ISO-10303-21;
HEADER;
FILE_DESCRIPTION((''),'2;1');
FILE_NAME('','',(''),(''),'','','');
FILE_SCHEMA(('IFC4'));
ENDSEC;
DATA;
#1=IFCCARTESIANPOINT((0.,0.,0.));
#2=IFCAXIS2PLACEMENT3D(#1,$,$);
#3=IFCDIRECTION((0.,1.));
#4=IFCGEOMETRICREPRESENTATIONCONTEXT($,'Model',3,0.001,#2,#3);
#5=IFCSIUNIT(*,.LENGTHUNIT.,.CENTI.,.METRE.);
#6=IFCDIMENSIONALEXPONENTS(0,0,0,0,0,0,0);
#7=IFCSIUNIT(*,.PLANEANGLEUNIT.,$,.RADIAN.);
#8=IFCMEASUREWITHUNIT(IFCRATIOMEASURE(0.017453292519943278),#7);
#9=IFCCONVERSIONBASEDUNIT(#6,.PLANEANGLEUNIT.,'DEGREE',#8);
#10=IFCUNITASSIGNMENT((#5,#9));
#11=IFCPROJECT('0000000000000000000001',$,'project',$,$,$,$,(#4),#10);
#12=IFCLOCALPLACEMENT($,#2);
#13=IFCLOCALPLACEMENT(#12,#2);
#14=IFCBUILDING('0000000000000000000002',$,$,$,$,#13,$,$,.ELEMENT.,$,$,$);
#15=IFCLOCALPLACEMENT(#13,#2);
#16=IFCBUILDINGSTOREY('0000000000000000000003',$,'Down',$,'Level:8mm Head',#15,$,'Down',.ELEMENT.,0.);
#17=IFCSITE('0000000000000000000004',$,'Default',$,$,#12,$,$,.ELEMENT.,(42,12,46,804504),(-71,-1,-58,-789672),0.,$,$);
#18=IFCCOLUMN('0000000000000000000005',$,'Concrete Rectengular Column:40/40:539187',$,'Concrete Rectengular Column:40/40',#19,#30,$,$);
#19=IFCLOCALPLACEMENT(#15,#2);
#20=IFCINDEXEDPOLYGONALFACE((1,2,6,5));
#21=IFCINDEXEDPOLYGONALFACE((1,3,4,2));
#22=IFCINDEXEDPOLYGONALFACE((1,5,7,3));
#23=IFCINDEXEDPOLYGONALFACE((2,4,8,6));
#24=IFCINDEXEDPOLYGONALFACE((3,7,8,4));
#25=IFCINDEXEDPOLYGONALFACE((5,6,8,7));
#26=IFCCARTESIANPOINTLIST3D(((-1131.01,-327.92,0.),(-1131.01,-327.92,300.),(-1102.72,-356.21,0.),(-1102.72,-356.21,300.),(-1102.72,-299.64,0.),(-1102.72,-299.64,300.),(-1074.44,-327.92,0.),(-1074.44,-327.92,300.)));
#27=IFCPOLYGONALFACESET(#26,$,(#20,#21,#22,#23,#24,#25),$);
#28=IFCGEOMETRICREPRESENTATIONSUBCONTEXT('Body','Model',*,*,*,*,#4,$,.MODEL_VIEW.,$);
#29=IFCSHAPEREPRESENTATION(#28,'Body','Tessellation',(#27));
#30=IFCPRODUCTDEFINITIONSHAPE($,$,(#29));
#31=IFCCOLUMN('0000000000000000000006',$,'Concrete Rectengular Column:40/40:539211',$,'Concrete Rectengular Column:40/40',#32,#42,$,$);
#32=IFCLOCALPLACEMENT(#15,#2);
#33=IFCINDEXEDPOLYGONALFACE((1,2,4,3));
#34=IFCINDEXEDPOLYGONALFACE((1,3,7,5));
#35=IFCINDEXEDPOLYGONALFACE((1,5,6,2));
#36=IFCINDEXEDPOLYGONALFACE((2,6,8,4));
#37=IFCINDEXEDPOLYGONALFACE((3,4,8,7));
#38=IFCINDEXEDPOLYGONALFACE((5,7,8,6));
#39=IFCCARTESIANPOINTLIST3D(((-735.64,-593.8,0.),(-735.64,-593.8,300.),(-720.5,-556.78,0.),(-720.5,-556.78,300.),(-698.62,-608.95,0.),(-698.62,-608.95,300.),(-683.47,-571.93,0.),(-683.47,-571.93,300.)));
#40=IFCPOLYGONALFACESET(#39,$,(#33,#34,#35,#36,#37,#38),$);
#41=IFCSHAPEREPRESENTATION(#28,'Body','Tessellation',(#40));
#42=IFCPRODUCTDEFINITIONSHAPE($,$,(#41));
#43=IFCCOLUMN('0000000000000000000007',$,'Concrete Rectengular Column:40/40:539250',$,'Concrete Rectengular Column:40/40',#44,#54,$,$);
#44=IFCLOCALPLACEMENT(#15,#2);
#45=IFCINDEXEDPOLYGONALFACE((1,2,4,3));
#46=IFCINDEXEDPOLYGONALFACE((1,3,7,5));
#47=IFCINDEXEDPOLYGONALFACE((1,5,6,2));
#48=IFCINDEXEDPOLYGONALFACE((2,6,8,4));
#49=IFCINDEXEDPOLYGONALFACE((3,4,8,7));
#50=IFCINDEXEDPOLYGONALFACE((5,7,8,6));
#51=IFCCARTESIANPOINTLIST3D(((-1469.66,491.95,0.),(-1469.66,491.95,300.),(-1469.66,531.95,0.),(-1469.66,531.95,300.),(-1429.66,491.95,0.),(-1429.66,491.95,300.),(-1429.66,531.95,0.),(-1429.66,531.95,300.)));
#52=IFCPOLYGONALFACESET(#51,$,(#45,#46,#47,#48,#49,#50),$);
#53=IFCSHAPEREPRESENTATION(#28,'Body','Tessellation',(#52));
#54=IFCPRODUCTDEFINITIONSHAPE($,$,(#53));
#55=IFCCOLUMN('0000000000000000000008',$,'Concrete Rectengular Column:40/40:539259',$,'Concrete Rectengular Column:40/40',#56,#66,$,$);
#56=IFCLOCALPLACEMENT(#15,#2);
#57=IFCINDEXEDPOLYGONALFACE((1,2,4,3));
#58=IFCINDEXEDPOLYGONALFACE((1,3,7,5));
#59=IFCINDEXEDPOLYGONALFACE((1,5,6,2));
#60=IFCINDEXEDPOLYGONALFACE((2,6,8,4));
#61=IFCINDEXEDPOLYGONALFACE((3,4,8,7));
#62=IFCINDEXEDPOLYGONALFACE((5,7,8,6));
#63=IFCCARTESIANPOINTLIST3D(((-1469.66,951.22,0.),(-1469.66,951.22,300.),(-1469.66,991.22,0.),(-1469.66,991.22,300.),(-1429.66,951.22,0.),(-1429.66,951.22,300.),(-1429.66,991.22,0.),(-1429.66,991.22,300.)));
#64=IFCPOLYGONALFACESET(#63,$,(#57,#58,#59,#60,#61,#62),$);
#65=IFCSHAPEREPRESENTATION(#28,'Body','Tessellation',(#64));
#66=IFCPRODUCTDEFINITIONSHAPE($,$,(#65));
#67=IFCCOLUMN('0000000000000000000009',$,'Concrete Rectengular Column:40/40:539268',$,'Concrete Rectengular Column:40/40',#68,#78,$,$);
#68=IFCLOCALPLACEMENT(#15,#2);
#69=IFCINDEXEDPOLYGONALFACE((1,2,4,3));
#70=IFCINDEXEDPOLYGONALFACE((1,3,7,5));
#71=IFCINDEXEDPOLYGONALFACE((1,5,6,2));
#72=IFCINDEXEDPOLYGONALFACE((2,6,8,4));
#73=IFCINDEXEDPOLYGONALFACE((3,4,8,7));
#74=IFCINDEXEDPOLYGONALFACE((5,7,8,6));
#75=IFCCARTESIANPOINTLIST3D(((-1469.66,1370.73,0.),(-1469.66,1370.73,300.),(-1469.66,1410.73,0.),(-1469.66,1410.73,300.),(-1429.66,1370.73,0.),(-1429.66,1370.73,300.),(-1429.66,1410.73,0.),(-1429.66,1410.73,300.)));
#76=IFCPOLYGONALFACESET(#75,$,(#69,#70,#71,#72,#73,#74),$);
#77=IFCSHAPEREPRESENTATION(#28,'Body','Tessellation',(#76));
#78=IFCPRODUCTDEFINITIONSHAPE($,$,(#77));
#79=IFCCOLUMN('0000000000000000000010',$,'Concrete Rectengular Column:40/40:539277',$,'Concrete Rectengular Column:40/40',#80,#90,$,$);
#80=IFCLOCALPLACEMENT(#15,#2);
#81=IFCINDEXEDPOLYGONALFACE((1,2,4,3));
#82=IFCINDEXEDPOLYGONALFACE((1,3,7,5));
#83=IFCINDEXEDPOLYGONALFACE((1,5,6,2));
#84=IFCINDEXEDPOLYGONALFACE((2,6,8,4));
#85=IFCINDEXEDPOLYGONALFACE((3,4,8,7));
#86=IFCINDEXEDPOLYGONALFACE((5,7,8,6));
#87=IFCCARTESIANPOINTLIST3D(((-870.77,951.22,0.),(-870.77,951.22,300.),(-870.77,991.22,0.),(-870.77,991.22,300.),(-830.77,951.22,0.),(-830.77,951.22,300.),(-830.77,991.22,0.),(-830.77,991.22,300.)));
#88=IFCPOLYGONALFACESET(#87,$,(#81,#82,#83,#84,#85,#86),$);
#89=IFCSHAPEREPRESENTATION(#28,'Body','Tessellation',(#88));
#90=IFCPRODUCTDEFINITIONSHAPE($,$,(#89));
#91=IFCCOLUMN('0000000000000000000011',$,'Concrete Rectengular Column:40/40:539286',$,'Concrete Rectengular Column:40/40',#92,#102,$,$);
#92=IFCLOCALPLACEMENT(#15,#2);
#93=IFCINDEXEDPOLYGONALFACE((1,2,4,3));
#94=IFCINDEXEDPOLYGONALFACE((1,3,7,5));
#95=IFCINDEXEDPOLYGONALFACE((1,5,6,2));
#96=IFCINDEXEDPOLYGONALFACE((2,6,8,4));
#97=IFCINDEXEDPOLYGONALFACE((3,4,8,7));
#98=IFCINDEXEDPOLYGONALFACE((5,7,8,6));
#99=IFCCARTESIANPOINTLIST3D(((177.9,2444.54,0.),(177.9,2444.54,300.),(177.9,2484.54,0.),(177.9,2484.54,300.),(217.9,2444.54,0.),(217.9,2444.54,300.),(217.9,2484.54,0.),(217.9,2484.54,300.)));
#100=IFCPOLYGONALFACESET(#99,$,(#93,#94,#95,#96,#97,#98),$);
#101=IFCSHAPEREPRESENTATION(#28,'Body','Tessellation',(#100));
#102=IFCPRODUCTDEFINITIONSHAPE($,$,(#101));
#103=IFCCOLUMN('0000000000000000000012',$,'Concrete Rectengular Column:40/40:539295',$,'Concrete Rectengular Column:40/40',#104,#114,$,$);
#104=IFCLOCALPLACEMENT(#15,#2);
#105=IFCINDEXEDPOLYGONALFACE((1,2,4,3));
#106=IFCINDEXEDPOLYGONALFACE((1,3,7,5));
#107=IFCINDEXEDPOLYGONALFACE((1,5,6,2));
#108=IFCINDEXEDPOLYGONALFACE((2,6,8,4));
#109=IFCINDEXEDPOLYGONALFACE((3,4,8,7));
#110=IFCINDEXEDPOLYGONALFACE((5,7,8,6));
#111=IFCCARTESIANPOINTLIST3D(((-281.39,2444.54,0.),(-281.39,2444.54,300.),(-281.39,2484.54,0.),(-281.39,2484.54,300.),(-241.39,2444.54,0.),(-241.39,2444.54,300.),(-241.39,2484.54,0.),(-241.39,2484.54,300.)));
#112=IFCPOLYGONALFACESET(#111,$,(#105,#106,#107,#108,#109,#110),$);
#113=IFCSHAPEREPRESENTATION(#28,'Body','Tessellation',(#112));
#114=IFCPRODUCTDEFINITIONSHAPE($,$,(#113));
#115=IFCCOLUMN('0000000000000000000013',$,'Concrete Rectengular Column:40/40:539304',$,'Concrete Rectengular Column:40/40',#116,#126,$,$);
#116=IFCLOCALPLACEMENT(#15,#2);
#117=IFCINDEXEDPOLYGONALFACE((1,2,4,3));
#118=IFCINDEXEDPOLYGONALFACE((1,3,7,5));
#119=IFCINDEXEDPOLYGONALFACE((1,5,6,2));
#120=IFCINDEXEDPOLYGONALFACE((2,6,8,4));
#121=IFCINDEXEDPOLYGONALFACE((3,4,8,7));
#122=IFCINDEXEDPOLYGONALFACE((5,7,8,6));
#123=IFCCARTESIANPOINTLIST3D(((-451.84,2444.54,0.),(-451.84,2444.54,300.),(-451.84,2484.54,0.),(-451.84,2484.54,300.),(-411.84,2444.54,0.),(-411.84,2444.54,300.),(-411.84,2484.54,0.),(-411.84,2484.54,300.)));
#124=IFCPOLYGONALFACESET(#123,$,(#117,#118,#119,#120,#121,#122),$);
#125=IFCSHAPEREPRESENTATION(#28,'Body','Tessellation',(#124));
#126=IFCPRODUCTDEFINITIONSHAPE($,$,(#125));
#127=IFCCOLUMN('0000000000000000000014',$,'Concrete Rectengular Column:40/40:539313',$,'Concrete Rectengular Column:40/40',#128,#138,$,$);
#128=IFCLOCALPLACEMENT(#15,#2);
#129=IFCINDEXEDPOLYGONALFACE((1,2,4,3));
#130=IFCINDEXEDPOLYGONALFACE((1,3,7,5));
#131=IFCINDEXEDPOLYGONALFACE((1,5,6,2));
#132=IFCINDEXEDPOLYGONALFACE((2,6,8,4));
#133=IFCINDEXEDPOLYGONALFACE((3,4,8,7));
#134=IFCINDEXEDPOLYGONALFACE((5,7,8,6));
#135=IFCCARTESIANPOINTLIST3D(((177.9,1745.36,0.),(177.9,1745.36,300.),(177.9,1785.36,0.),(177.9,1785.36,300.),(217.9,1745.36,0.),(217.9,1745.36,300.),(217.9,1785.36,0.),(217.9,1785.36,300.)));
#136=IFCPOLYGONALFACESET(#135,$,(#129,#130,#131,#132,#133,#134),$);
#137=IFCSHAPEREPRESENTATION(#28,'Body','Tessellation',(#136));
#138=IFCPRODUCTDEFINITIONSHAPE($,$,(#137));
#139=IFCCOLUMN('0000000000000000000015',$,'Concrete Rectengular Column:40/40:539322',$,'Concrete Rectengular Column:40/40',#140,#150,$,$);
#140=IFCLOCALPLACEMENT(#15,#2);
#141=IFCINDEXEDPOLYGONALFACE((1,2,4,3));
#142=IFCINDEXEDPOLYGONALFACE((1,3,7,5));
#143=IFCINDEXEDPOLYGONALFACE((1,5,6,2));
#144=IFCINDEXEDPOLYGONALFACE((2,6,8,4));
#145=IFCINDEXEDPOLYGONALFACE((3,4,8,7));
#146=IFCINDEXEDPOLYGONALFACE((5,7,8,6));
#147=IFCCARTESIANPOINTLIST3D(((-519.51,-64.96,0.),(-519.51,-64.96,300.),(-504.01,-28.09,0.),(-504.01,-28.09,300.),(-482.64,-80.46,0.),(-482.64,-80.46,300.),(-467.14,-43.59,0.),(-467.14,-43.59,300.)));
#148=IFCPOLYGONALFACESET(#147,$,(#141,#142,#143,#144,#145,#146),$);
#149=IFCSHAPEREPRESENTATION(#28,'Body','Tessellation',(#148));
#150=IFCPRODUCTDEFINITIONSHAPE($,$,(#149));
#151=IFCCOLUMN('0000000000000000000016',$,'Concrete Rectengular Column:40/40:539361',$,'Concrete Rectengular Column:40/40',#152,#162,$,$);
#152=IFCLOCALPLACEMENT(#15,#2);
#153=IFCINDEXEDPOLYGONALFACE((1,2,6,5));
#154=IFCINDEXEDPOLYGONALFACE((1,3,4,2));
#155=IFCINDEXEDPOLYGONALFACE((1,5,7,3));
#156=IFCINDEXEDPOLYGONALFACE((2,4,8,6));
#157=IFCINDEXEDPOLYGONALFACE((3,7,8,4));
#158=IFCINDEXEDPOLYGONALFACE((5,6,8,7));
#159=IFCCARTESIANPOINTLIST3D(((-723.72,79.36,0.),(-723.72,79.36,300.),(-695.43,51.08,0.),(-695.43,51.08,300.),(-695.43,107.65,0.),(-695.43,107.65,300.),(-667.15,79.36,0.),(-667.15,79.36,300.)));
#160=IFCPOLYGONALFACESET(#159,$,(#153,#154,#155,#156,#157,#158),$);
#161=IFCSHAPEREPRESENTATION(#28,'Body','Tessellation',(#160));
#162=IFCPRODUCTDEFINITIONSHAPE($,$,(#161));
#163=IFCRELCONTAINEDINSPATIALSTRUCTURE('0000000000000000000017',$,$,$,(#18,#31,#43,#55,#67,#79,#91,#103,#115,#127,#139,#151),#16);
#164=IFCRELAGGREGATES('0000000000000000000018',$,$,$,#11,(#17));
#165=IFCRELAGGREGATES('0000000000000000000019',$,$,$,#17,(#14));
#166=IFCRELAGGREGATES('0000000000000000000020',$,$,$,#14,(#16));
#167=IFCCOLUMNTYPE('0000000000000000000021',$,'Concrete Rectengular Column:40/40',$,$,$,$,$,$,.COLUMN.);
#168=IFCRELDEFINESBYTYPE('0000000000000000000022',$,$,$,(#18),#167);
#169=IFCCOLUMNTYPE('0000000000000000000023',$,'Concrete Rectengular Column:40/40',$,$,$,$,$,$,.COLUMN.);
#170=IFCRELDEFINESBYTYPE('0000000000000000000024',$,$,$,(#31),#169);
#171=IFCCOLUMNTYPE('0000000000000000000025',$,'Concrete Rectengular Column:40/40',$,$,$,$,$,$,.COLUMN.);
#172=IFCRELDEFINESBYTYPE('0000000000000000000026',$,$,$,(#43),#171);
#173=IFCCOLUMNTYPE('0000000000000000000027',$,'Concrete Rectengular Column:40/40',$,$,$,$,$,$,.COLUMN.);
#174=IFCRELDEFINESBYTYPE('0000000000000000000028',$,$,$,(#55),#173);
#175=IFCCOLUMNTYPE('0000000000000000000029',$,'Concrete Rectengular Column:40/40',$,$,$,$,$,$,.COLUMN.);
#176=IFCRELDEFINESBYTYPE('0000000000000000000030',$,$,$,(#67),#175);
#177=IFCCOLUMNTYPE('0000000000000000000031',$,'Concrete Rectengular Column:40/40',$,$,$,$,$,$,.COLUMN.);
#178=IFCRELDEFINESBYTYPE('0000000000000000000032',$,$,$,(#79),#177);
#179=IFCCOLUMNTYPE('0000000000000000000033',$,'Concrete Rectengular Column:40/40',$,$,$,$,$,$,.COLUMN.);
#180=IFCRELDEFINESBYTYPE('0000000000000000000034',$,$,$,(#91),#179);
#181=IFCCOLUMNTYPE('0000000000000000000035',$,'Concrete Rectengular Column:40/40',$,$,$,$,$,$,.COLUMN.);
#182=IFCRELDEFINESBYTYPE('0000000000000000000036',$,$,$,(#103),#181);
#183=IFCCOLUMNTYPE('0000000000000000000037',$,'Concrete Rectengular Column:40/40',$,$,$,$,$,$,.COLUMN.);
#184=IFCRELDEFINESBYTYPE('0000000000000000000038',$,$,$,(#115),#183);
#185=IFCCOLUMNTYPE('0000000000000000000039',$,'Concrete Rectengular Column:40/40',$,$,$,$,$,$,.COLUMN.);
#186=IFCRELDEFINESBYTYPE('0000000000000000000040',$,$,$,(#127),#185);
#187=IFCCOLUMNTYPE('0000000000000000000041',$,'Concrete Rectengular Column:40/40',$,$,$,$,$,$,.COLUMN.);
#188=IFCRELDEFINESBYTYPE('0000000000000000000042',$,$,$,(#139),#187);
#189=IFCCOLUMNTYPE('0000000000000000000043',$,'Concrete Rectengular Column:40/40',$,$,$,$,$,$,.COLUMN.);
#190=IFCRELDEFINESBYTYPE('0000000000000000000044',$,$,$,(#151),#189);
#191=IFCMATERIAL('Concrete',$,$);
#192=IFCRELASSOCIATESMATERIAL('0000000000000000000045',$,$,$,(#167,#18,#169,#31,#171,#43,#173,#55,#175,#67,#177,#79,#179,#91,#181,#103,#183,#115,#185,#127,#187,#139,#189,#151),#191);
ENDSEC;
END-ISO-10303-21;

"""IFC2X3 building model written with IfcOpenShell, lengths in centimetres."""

from ifc_helpers import new_model, entity, si_unit, converted_unit, direction, frame, frame_2d, origin, origin_2d_with_axis, place, context, subcontext, project, spatial, rectangle, extrude, source, transform, mapped, material, type_object, type_shapes, element, save


model = new_model("IFC2X3")

# Units and contexts
model_context = context("Model", 3, precision=0.001, world=origin(), true_north=direction((0.0, 1.0)))
body_context = subcontext(model_context, "Body", "Model", "MODEL_VIEW")
ifc_project = project(units=[si_unit("LENGTHUNIT", "METRE", prefix="CENTI"), converted_unit("PLANEANGLEUNIT", "DEGREE", entity("IfcRatioMeasure", 0.017453292519943278), si_unit("PLANEANGLEUNIT", "RADIAN"), dimensions=[0, 0, 0, 0, 0, 0, 0])], contexts=[model_context])

# Site, building, storey
site_placement = place(None, origin())
site = spatial("IfcSite", under=ifc_project, at=site_placement, Name="Default", CompositionType="ELEMENT", RefLatitude=(42, 12, 46, 804504), RefLongitude=(-71, -1, -58, -789672), RefElevation=0.0)
building_placement = place(site_placement, origin())
building = spatial("IfcBuilding", under=site, at=building_placement, CompositionType="ELEMENT")
storey_placement = place(building_placement, origin())
storey = spatial("IfcBuildingStorey", under=building, at=storey_placement, Name="Down", ObjectType="Level:8mm Head", LongName="Down", CompositionType="ELEMENT", Elevation=0.0)

# Columns
ifc_material = material(Name="Concrete")
column_type_1 = type_object("IfcColumnType", Name="Concrete Rectengular Column:40/40", PredefinedType="COLUMN", material=ifc_material)
shared_shape_1 = source(origin(), body_context, "Body", "SweptSolid", [
    extrude(rectangle(XDim=40.0, YDim=40.0, at=frame_2d((0.0, 0.0), x_axis=(1.0, 0.0))), frame((-1102.72, -327.92, 0.0), z_axis=(0.0, 0.0, 1.0), x_axis=(0.707107, 0.707107, 0.0)), (0.0, 0.0, 1.0), 300.0),
])
type_shapes(column_type_1, [shared_shape_1])
column_1_placement = place(storey_placement, origin())
element("IfcColumn", 1, at=column_1_placement, inside=storey, type_object=column_type_1, material=ifc_material, Name="Concrete Rectengular Column:40/40:539187", ObjectType="Concrete Rectengular Column:40/40", context=body_context, shape_type="MappedRepresentation", body=[
    mapped(shared_shape_1, transform((0.0, 0.0, 0.0), scale=1.0)),
])
column_type_2 = type_object("IfcColumnType", Name="Concrete Rectengular Column:40/40", PredefinedType="COLUMN", material=ifc_material)
shared_shape_2 = source(origin(), body_context, "Body", "SweptSolid", [
    extrude(rectangle(XDim=40.0, YDim=40.0, at=frame_2d((0.0, 0.0), x_axis=(1.0, 0.0))), frame((-709.56, -582.86, 0.0), z_axis=(0.0, 0.0, 1.0), x_axis=(-0.925555, 0.378612, 0.0)), (0.0, 0.0, 1.0), 300.0),
])
type_shapes(column_type_2, [shared_shape_2])
column_2_placement = place(storey_placement, origin())
element("IfcColumn", 2, at=column_2_placement, inside=storey, type_object=column_type_2, material=ifc_material, Name="Concrete Rectengular Column:40/40:539211", ObjectType="Concrete Rectengular Column:40/40", context=body_context, shape_type="MappedRepresentation", body=[
    mapped(shared_shape_2, transform((0.0, 0.0, 0.0), scale=1.0)),
])
column_type_3 = type_object("IfcColumnType", Name="Concrete Rectengular Column:40/40", PredefinedType="COLUMN", material=ifc_material)
shared_shape_3 = source(origin(), body_context, "Body", "SweptSolid", [
    extrude(rectangle(XDim=40.0, YDim=40.0, at=frame_2d((0.0, 0.0), x_axis=(1.0, 0.0))), frame((-1449.66, 511.95, 0.0), z_axis=(0.0, 0.0, 1.0), x_axis=(0.0, -1.0, 0.0)), (0.0, 0.0, 1.0), 300.0),
])
type_shapes(column_type_3, [shared_shape_3])
column_3_placement = place(storey_placement, origin())
element("IfcColumn", 3, at=column_3_placement, inside=storey, type_object=column_type_3, material=ifc_material, Name="Concrete Rectengular Column:40/40:539250", ObjectType="Concrete Rectengular Column:40/40", context=body_context, shape_type="MappedRepresentation", body=[
    mapped(shared_shape_3, transform((0.0, 0.0, 0.0), scale=1.0)),
])
column_type_4 = type_object("IfcColumnType", Name="Concrete Rectengular Column:40/40", PredefinedType="COLUMN", material=ifc_material)
shared_shape_4 = source(origin(), body_context, "Body", "SweptSolid", [
    extrude(rectangle(XDim=40.0, YDim=40.0, at=frame_2d((0.0, 0.0), x_axis=(1.0, 0.0))), frame((-1449.66, 971.22, 0.0), z_axis=(0.0, 0.0, 1.0), x_axis=(0.0, -1.0, 0.0)), (0.0, 0.0, 1.0), 300.0),
])
type_shapes(column_type_4, [shared_shape_4])
column_4_placement = place(storey_placement, origin())
element("IfcColumn", 4, at=column_4_placement, inside=storey, type_object=column_type_4, material=ifc_material, Name="Concrete Rectengular Column:40/40:539259", ObjectType="Concrete Rectengular Column:40/40", context=body_context, shape_type="MappedRepresentation", body=[
    mapped(shared_shape_4, transform((0.0, 0.0, 0.0), scale=1.0)),
])
column_type_5 = type_object("IfcColumnType", Name="Concrete Rectengular Column:40/40", PredefinedType="COLUMN", material=ifc_material)
shared_shape_5 = source(origin(), body_context, "Body", "SweptSolid", [
    extrude(rectangle(XDim=40.0, YDim=40.0, at=frame_2d((0.0, 0.0), x_axis=(1.0, 0.0))), frame((-1449.66, 1390.73, 0.0), z_axis=(0.0, 0.0, 1.0), x_axis=(0.0, -1.0, 0.0)), (0.0, 0.0, 1.0), 300.0),
])
type_shapes(column_type_5, [shared_shape_5])
column_5_placement = place(storey_placement, origin())
element("IfcColumn", 5, at=column_5_placement, inside=storey, type_object=column_type_5, material=ifc_material, Name="Concrete Rectengular Column:40/40:539268", ObjectType="Concrete Rectengular Column:40/40", context=body_context, shape_type="MappedRepresentation", body=[
    mapped(shared_shape_5, transform((0.0, 0.0, 0.0), scale=1.0)),
])
column_type_6 = type_object("IfcColumnType", Name="Concrete Rectengular Column:40/40", PredefinedType="COLUMN", material=ifc_material)
shared_shape_6 = source(origin(), body_context, "Body", "SweptSolid", [
    extrude(rectangle(XDim=40.0, YDim=40.0, at=origin_2d_with_axis()), frame((-850.77, 971.22, 0.0), z_axis=(0.0, 0.0, 1.0), x_axis=(0.0, -1.0, 0.0)), (0.0, 0.0, 1.0), 300.0),
])
type_shapes(column_type_6, [shared_shape_6])
column_6_placement = place(storey_placement, origin())
element("IfcColumn", 6, at=column_6_placement, inside=storey, type_object=column_type_6, material=ifc_material, Name="Concrete Rectengular Column:40/40:539277", ObjectType="Concrete Rectengular Column:40/40", context=body_context, shape_type="MappedRepresentation", body=[
    mapped(shared_shape_6, transform((0.0, 0.0, 0.0), scale=1.0)),
])
column_type_7 = type_object("IfcColumnType", Name="Concrete Rectengular Column:40/40", PredefinedType="COLUMN", material=ifc_material)
shared_shape_7 = source(origin(), body_context, "Body", "SweptSolid", [
    extrude(rectangle(XDim=40.0, YDim=40.0, at=frame_2d((0.0, 0.0), x_axis=(1.0, 0.0))), frame((197.9, 2464.54, 0.0), z_axis=(0.0, 0.0, 1.0), x_axis=(0.0, -1.0, 0.0)), (0.0, 0.0, 1.0), 300.0),
])
type_shapes(column_type_7, [shared_shape_7])
column_7_placement = place(storey_placement, origin())
element("IfcColumn", 7, at=column_7_placement, inside=storey, type_object=column_type_7, material=ifc_material, Name="Concrete Rectengular Column:40/40:539286", ObjectType="Concrete Rectengular Column:40/40", context=body_context, shape_type="MappedRepresentation", body=[
    mapped(shared_shape_7, transform((0.0, 0.0, 0.0), scale=1.0)),
])
column_type_8 = type_object("IfcColumnType", Name="Concrete Rectengular Column:40/40", PredefinedType="COLUMN", material=ifc_material)
shared_shape_8 = source(origin(), body_context, "Body", "SweptSolid", [
    extrude(rectangle(XDim=40.0, YDim=40.0, at=frame_2d((0.0, 0.0), x_axis=(1.0, 0.0))), frame((-261.39, 2464.54, 0.0), z_axis=(0.0, 0.0, 1.0), x_axis=(0.0, -1.0, 0.0)), (0.0, 0.0, 1.0), 300.0),
])
type_shapes(column_type_8, [shared_shape_8])
column_8_placement = place(storey_placement, origin())
element("IfcColumn", 8, at=column_8_placement, inside=storey, type_object=column_type_8, material=ifc_material, Name="Concrete Rectengular Column:40/40:539295", ObjectType="Concrete Rectengular Column:40/40", context=body_context, shape_type="MappedRepresentation", body=[
    mapped(shared_shape_8, transform((0.0, 0.0, 0.0), scale=1.0)),
])
column_type_9 = type_object("IfcColumnType", Name="Concrete Rectengular Column:40/40", PredefinedType="COLUMN", material=ifc_material)
shared_shape_9 = source(origin(), body_context, "Body", "SweptSolid", [
    extrude(rectangle(XDim=40.0, YDim=40.0, at=frame_2d((0.0, 0.0), x_axis=(1.0, 0.0))), frame((-431.84, 2464.54, 0.0), z_axis=(0.0, 0.0, 1.0), x_axis=(0.0, -1.0, 0.0)), (0.0, 0.0, 1.0), 300.0),
])
type_shapes(column_type_9, [shared_shape_9])
column_9_placement = place(storey_placement, origin())
element("IfcColumn", 9, at=column_9_placement, inside=storey, type_object=column_type_9, material=ifc_material, Name="Concrete Rectengular Column:40/40:539304", ObjectType="Concrete Rectengular Column:40/40", context=body_context, shape_type="MappedRepresentation", body=[
    mapped(shared_shape_9, transform((0.0, 0.0, 0.0), scale=1.0)),
])
column_type_10 = type_object("IfcColumnType", Name="Concrete Rectengular Column:40/40", PredefinedType="COLUMN", material=ifc_material)
shared_shape_10 = source(origin(), body_context, "Body", "SweptSolid", [
    extrude(rectangle(XDim=40.0, YDim=40.0, at=frame_2d((0.0, 0.0), x_axis=(1.0, 0.0))), frame((197.9, 1765.36, 0.0), z_axis=(0.0, 0.0, 1.0), x_axis=(0.0, -1.0, 0.0)), (0.0, 0.0, 1.0), 300.0),
])
type_shapes(column_type_10, [shared_shape_10])
column_10_placement = place(storey_placement, origin())
element("IfcColumn", 10, at=column_10_placement, inside=storey, type_object=column_type_10, material=ifc_material, Name="Concrete Rectengular Column:40/40:539313", ObjectType="Concrete Rectengular Column:40/40", context=body_context, shape_type="MappedRepresentation", body=[
    mapped(shared_shape_10, transform((0.0, 0.0, 0.0), scale=1.0)),
])
column_type_11 = type_object("IfcColumnType", Name="Concrete Rectengular Column:40/40", PredefinedType="COLUMN", material=ifc_material)
shared_shape_11 = source(origin(), body_context, "Body", "SweptSolid", [
    extrude(rectangle(XDim=40.0, YDim=40.0, at=frame_2d((0.0, 0.0), x_axis=(1.0, 0.0))), frame((-493.32, -54.27, 0.0), z_axis=(0.0, 0.0, 1.0), x_axis=(-0.921888, 0.387456, 0.0)), (0.0, 0.0, 1.0), 300.0),
])
type_shapes(column_type_11, [shared_shape_11])
column_11_placement = place(storey_placement, origin())
element("IfcColumn", 11, at=column_11_placement, inside=storey, type_object=column_type_11, material=ifc_material, Name="Concrete Rectengular Column:40/40:539322", ObjectType="Concrete Rectengular Column:40/40", context=body_context, shape_type="MappedRepresentation", body=[
    mapped(shared_shape_11, transform((0.0, 0.0, 0.0), scale=1.0)),
])
column_type_12 = type_object("IfcColumnType", Name="Concrete Rectengular Column:40/40", PredefinedType="COLUMN", material=ifc_material)
shared_shape_12 = source(origin(), body_context, "Body", "SweptSolid", [
    extrude(rectangle(XDim=40.0, YDim=40.0, at=frame_2d((0.0, 0.0), x_axis=(1.0, 0.0))), frame((-695.43, 79.36, 0.0), z_axis=(0.0, 0.0, 1.0), x_axis=(0.707107, 0.707107, 0.0)), (0.0, 0.0, 1.0), 300.0),
])
type_shapes(column_type_12, [shared_shape_12])
column_12_placement = place(storey_placement, origin())
element("IfcColumn", 12, at=column_12_placement, inside=storey, type_object=column_type_12, material=ifc_material, Name="Concrete Rectengular Column:40/40:539361", ObjectType="Concrete Rectengular Column:40/40", context=body_context, shape_type="MappedRepresentation", body=[
    mapped(shared_shape_12, transform((0.0, 0.0, 0.0), scale=1.0)),
])

save(model, "model.ifc")
